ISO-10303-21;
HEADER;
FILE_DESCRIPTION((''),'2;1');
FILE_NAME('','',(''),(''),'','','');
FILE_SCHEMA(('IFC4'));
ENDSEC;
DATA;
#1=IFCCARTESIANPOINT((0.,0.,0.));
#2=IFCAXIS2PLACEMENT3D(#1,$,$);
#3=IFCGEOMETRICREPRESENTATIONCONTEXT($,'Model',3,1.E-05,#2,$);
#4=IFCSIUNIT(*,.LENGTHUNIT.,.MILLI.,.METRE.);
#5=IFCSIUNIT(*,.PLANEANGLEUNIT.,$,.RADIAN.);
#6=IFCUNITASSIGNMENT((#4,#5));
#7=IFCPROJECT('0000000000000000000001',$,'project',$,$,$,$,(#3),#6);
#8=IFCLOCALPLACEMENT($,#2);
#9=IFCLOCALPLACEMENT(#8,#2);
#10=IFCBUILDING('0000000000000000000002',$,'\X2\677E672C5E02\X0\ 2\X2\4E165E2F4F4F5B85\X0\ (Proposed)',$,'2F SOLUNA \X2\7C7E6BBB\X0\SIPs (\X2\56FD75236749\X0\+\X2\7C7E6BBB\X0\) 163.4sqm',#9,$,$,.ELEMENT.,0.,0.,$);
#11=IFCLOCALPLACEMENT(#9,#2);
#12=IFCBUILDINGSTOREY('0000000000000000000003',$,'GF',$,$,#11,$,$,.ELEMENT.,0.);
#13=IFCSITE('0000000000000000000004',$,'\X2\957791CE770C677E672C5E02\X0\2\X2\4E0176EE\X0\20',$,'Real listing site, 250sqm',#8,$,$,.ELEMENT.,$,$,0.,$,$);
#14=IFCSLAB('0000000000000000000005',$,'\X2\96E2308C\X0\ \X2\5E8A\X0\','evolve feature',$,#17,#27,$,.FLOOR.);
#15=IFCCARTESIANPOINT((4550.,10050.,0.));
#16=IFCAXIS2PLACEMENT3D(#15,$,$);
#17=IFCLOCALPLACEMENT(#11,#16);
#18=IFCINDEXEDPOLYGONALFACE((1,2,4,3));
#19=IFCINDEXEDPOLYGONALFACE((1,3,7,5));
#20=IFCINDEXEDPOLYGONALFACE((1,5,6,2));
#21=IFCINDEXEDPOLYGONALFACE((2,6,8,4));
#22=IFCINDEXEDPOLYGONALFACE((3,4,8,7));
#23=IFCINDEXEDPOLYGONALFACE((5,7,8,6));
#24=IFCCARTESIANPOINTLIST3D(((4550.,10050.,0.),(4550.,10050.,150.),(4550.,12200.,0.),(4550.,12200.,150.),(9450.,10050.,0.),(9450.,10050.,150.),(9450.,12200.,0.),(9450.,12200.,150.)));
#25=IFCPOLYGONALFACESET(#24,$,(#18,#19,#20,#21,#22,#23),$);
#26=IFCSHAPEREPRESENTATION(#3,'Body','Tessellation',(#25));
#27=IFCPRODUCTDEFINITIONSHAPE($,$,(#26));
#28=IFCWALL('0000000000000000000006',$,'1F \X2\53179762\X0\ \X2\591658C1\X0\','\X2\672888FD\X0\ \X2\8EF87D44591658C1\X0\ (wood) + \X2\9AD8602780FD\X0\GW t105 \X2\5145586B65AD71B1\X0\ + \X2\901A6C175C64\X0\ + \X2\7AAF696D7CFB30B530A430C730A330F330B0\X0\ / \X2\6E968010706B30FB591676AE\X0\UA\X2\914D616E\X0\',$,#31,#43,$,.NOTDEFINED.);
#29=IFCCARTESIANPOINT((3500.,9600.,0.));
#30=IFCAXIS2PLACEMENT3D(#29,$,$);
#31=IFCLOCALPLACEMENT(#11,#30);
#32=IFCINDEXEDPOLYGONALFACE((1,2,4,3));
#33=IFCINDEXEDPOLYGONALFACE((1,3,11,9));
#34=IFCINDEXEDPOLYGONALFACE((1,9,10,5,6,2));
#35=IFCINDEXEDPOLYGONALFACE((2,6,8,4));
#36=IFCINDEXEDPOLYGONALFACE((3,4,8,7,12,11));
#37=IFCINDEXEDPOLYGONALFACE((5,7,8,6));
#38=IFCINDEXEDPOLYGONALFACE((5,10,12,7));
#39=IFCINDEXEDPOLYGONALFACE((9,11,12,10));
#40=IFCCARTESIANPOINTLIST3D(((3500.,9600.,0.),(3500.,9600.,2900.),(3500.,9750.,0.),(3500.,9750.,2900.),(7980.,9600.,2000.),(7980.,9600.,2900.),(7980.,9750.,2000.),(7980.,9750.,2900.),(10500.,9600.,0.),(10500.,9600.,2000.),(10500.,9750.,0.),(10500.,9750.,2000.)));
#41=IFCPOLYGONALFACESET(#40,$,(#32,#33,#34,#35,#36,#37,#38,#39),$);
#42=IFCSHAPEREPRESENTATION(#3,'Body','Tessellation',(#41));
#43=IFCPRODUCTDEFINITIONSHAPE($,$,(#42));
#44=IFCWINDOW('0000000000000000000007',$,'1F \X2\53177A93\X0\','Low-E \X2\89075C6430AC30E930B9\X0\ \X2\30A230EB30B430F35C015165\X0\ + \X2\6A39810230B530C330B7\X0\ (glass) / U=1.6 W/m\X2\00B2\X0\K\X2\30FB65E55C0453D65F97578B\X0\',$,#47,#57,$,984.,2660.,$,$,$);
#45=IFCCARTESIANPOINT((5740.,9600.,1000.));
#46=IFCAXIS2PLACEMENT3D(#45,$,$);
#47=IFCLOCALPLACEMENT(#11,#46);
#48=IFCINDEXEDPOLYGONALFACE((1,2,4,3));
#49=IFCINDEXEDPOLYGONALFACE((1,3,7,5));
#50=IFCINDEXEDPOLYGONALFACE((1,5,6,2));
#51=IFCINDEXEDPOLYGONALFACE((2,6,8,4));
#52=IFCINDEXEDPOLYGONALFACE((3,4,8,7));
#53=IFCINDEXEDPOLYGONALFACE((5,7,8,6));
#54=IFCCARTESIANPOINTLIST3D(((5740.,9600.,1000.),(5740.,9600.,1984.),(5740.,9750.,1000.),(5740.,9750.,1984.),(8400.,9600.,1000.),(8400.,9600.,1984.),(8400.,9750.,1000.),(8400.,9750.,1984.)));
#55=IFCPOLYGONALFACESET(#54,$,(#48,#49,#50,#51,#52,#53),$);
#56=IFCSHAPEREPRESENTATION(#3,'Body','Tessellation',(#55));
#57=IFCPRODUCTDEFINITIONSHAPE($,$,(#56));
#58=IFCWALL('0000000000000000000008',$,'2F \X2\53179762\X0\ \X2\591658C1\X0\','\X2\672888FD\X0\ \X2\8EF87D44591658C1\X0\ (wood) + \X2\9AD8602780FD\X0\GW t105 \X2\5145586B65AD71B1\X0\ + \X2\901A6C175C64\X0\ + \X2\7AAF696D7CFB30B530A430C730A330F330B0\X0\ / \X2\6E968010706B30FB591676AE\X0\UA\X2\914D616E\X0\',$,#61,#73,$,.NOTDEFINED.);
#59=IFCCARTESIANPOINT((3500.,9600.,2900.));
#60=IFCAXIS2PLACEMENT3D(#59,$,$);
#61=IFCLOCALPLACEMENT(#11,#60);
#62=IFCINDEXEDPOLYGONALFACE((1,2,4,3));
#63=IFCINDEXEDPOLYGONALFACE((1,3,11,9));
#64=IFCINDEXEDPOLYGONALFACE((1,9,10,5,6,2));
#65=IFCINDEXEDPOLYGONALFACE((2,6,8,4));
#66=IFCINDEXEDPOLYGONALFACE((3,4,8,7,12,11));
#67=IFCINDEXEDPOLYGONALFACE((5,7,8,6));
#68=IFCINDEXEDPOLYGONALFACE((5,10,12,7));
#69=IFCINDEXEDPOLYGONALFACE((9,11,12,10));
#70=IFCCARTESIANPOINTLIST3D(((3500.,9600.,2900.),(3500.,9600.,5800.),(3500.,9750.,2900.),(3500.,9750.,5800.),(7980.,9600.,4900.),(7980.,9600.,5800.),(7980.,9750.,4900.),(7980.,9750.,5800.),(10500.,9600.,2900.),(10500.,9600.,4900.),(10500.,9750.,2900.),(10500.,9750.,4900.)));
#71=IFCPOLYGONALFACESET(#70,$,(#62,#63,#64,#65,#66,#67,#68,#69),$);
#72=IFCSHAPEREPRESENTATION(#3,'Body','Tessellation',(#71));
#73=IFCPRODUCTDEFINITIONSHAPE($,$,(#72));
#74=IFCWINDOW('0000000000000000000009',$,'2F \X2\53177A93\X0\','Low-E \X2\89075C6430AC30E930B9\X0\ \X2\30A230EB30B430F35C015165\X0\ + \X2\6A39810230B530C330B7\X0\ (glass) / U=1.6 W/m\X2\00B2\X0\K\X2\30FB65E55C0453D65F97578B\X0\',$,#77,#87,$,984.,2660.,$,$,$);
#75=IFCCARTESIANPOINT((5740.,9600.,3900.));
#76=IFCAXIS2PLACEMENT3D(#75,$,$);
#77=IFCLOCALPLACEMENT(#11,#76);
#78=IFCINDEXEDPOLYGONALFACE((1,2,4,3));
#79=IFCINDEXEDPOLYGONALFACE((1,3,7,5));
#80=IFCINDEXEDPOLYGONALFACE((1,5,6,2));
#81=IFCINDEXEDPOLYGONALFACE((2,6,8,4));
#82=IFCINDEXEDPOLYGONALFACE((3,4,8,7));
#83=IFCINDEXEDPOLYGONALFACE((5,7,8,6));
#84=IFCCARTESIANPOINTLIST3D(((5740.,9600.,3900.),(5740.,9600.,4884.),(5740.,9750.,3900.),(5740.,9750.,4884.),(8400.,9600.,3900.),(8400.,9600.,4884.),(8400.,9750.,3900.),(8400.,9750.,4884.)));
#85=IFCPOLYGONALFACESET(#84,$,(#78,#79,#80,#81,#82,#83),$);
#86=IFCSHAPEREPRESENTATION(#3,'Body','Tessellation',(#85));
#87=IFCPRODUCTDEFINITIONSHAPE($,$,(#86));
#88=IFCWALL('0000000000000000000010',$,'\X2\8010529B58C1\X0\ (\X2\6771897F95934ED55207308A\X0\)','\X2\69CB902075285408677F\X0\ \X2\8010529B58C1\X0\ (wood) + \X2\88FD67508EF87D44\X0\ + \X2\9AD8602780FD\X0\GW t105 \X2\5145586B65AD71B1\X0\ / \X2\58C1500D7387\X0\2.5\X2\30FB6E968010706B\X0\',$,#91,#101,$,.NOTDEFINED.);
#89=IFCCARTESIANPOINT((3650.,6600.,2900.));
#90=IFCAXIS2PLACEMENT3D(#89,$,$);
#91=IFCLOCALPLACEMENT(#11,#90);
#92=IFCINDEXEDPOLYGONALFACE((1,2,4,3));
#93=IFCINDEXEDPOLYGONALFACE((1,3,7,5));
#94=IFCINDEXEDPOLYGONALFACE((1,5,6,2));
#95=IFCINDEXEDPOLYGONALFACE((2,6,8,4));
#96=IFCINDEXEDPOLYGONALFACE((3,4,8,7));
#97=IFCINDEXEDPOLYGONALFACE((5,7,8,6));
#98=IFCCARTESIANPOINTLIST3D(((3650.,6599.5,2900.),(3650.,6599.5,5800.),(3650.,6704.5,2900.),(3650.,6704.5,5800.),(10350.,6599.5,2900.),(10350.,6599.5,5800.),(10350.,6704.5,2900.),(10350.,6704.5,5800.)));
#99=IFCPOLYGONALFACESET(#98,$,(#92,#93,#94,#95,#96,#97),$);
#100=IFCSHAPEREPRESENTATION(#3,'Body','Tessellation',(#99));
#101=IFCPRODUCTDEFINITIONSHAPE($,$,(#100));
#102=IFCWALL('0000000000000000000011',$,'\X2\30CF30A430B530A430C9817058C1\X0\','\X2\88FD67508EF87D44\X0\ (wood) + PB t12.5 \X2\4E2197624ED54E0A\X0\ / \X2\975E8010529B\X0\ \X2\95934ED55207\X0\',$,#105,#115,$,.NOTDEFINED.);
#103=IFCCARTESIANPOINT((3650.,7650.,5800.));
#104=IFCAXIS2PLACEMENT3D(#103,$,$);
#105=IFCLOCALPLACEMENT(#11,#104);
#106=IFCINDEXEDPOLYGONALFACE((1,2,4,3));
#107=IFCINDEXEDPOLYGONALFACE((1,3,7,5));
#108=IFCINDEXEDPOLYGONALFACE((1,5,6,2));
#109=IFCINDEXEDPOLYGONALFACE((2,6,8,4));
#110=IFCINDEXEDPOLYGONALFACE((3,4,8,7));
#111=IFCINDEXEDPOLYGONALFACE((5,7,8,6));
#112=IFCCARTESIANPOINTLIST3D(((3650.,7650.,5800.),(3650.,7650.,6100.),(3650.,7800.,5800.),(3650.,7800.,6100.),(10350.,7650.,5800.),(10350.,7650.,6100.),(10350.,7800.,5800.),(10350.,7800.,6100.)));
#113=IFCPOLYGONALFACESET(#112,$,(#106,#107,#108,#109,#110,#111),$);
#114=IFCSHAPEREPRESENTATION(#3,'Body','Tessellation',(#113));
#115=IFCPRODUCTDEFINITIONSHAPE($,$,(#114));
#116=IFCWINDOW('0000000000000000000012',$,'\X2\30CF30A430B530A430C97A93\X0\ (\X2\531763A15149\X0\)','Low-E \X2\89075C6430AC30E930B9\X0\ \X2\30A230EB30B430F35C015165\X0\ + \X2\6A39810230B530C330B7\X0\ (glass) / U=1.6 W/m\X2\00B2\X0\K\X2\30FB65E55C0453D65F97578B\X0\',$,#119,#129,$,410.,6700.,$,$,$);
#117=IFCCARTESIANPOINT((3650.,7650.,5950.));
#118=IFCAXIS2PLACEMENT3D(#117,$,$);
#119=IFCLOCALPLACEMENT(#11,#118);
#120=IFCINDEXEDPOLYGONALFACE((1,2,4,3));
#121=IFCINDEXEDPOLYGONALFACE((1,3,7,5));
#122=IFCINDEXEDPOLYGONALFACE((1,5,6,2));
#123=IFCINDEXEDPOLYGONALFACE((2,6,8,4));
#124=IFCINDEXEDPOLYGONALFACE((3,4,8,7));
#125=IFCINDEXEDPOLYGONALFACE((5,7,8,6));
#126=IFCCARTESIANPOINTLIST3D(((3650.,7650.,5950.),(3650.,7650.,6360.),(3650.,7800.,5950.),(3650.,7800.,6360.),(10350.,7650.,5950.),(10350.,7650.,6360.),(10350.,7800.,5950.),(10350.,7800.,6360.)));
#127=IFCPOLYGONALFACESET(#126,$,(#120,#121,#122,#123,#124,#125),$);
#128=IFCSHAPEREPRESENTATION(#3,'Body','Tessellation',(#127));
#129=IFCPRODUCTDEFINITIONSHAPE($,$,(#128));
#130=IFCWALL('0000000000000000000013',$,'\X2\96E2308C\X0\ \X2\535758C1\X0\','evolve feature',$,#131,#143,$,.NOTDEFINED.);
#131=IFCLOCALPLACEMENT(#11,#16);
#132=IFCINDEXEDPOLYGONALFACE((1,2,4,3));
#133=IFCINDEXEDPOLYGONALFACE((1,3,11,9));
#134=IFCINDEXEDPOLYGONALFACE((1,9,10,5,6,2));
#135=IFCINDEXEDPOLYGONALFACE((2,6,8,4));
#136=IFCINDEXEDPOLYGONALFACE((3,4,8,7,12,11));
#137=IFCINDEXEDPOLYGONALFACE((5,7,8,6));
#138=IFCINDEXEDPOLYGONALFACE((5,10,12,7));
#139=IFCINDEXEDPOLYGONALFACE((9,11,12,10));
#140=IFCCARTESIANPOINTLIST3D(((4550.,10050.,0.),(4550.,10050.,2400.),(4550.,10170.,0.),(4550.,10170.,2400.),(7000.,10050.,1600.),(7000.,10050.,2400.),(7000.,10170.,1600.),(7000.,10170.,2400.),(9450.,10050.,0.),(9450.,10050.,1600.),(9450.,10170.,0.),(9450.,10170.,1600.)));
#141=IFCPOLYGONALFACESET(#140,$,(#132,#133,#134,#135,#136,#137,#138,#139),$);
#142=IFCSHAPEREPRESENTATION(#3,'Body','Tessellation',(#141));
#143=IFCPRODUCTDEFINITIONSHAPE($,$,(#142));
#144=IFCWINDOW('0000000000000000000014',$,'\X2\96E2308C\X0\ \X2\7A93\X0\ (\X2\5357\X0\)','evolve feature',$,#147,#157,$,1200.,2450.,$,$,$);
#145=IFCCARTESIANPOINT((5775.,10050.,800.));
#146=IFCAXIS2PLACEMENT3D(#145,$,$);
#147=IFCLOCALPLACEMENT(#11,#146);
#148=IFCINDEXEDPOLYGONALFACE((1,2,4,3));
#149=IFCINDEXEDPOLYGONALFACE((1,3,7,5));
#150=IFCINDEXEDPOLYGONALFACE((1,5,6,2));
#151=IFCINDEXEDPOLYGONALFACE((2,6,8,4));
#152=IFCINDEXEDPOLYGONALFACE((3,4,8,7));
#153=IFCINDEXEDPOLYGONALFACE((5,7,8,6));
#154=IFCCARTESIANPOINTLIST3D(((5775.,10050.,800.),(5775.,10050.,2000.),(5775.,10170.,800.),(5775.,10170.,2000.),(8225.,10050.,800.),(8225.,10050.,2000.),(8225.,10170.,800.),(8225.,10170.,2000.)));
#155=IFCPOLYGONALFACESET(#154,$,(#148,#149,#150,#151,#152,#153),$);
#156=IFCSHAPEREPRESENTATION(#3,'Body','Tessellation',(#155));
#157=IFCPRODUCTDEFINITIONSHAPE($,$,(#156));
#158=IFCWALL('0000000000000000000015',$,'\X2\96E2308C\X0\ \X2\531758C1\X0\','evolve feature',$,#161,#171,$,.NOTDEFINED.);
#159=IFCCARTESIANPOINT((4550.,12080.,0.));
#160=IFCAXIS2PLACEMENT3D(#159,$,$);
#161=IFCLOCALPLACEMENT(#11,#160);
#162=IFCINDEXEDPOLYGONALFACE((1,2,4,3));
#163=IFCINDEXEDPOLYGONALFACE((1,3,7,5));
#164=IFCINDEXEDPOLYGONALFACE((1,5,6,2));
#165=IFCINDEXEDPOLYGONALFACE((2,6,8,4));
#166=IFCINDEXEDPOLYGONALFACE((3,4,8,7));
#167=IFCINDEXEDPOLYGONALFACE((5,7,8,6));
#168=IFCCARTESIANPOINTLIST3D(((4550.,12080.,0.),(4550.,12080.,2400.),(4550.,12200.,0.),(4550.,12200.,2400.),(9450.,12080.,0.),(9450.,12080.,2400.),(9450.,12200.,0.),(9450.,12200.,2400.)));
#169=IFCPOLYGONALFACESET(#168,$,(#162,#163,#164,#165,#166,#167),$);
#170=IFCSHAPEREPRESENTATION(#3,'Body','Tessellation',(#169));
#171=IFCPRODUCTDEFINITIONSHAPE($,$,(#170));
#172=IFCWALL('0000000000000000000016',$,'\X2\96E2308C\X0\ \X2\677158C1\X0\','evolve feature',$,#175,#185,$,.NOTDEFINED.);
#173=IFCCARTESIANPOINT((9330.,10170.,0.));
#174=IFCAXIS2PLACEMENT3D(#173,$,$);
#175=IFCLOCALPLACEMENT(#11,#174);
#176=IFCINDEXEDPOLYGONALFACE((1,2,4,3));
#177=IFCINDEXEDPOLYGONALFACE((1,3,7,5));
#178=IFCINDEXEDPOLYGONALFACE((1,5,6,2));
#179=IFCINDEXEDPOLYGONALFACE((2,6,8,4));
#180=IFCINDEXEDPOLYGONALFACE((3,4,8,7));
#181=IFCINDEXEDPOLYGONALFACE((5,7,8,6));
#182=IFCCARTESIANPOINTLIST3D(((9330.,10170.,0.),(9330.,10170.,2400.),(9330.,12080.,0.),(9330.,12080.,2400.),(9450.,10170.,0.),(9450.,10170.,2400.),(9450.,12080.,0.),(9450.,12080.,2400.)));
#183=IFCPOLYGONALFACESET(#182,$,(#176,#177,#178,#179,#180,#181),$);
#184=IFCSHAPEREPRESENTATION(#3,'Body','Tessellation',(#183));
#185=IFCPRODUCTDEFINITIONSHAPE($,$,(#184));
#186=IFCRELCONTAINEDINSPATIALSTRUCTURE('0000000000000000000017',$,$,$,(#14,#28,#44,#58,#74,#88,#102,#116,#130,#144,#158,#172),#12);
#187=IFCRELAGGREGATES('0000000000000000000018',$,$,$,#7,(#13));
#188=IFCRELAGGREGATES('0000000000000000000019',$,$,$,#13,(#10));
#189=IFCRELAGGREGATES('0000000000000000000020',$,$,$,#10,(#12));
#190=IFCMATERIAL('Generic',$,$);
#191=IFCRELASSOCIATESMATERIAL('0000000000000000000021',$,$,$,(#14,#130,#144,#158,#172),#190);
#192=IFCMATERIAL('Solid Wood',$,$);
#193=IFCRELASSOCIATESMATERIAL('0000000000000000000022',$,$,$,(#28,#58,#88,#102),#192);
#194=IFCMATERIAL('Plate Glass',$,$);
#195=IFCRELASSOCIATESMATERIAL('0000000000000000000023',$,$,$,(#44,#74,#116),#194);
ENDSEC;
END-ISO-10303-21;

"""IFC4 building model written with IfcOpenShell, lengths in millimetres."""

from ifc_helpers import new_model, si_unit, frame, frame_2d, origin, place, context, project, spatial, rectangle, extrude, material, element, fill, save


model = new_model("IFC4")

# Units and contexts
model_context = context("Model", 3, precision=1e-05, world=origin())
ifc_project = project(units=[si_unit("LENGTHUNIT", "METRE", prefix="MILLI"), si_unit("PLANEANGLEUNIT", "RADIAN")], contexts=[model_context])

# Site, building, storey
site_placement = place(None, origin())
site = spatial("IfcSite", under=ifc_project, at=site_placement, Name="長野県松本市2丁目20", ObjectType="Real listing site, 250sqm", CompositionType="ELEMENT", RefElevation=0.0)
building_placement = place(site_placement, origin())
building = spatial("IfcBuilding", under=site, at=building_placement, Name="松本市 2世帯住宅 (Proposed)", ObjectType="2F SOLUNA 籾殻SIPs (国産杉+籾殻) 163.4sqm", CompositionType="ELEMENT", ElevationOfRefHeight=0.0, ElevationOfTerrain=0.0)
storey_placement = place(building_placement, origin())
storey = spatial("IfcBuildingStorey", under=building, at=storey_placement, Name="GF", CompositionType="ELEMENT", Elevation=0.0)

# Slab
ifc_material_1 = material(Name="Generic")
slab_placement = place(storey_placement, frame((4550.0, 10050.0, 0.0)))
element("IfcSlab", 1, at=slab_placement, inside=storey, material=ifc_material_1, Name="離れ 床", Description="evolve feature", PredefinedType="FLOOR", context=model_context, shape_type="SweptSolid", body=[
    extrude(rectangle(XDim=4900.0, YDim=2150.0, at=frame_2d((2450.0, 1075.0))), frame((4550.0, 10050.0, 0.0)), (0.0, 0.0, 1.0), 150.0),
])

# Wall, opening, window
ifc_material_2 = material(Name="Solid Wood")
wall_1_placement = place(storey_placement, frame((3500.0, 9600.0, 0.0)))
wall_1 = element("IfcWall", 2, at=wall_1_placement, inside=storey, material=ifc_material_2, Name="1F 北面 外壁", Description="木製 軸組外壁 (wood) + 高性能GW t105 充填断熱 + 通気層 + 窯業系サイディング / 準耐火・外皮UA配慮", PredefinedType="NOTDEFINED", context=model_context, shape_type="SweptSolid", body=[
    extrude(rectangle(XDim=7000.0, YDim=150.0, at=frame_2d((3500.0, 75.0))), frame((3500.0, 9600.0, 0.0)), (0.0, 0.0, 1.0), 2900.0),
])
opening_1_placement = place(storey_placement, frame((5740.0, 9600.0, 1000.0)))
opening_1 = element("IfcOpeningElement", 3, at=opening_1_placement, cuts=wall_1, PredefinedType="NOTDEFINED", context=model_context, shape_type="SweptSolid", body=[
    extrude(rectangle(XDim=2660.0, YDim=150.0, at=frame_2d((1330.0, 75.0))), frame((5740.0, 9600.0, 1000.0)), (0.0, 0.0, 1.0), 984.0),
])
ifc_material_3 = material(Name="Plate Glass")
window_1_placement = place(storey_placement, frame((5740.0, 9600.0, 1000.0)))
window_1 = element("IfcWindow", 4, at=window_1_placement, inside=storey, material=ifc_material_3, Name="1F 北窓", Description="Low-E 複層ガラス アルゴン封入 + 樹脂サッシ (glass) / U=1.6 W/m²K・日射取得型", OverallHeight=984.0, OverallWidth=2660.0, context=model_context, shape_type="SweptSolid", body=[
    extrude(rectangle(XDim=2660.0, YDim=150.0, at=frame_2d((1330.0, 75.0))), frame((5740.0, 9600.0, 1000.0)), (0.0, 0.0, 1.0), 984.0),
])
fill(opening_1, window_1)

# Wall, opening, window
wall_2_placement = place(storey_placement, frame((3500.0, 9600.0, 2900.0)))
wall_2 = element("IfcWall", 5, at=wall_2_placement, inside=storey, material=ifc_material_2, Name="2F 北面 外壁", Description="木製 軸組外壁 (wood) + 高性能GW t105 充填断熱 + 通気層 + 窯業系サイディング / 準耐火・外皮UA配慮", PredefinedType="NOTDEFINED", context=model_context, shape_type="SweptSolid", body=[
    extrude(rectangle(XDim=7000.0, YDim=150.0, at=frame_2d((3500.0, 75.0))), frame((3500.0, 9600.0, 2900.0)), (0.0, 0.0, 1.0), 2900.0),
])
opening_2_placement = place(storey_placement, frame((5740.0, 9600.0, 3900.0)))
opening_2 = element("IfcOpeningElement", 6, at=opening_2_placement, cuts=wall_2, PredefinedType="NOTDEFINED", context=model_context, shape_type="SweptSolid", body=[
    extrude(rectangle(XDim=2660.0, YDim=150.0, at=frame_2d((1330.0, 75.0))), frame((5740.0, 9600.0, 3900.0)), (0.0, 0.0, 1.0), 984.0),
])
window_2_placement = place(storey_placement, frame((5740.0, 9600.0, 3900.0)))
window_2 = element("IfcWindow", 7, at=window_2_placement, inside=storey, material=ifc_material_3, Name="2F 北窓", Description="Low-E 複層ガラス アルゴン封入 + 樹脂サッシ (glass) / U=1.6 W/m²K・日射取得型", OverallHeight=984.0, OverallWidth=2660.0, context=model_context, shape_type="SweptSolid", body=[
    extrude(rectangle(XDim=2660.0, YDim=150.0, at=frame_2d((1330.0, 75.0))), frame((5740.0, 9600.0, 3900.0)), (0.0, 0.0, 1.0), 984.0),
])
fill(opening_2, window_2)

# Wall
wall_3_placement = place(storey_placement, frame((3650.0, 6600.0, 2900.0)))
element("IfcWall", 8, at=wall_3_placement, inside=storey, material=ifc_material_2, Name="耐力壁 (東西間仕切り)", Description="構造用合板 耐力壁 (wood) + 製材軸組 + 高性能GW t105 充填断熱 / 壁倍率2.5・準耐火", PredefinedType="NOTDEFINED", context=model_context, shape_type="SweptSolid", body=[
    extrude(rectangle(XDim=6700.0, YDim=105.0, at=frame_2d((3350.0, 52.0))), frame((3650.0, 6600.0, 2900.0)), (0.0, 0.0, 1.0), 2900.0),
])

# Walls, openings, windows
wall_4_placement = place(storey_placement, frame((3650.0, 7650.0, 5800.0)))
wall_4 = element("IfcWall", 9, at=wall_4_placement, inside=storey, material=ifc_material_2, Name="ハイサイド腰壁", Description="製材軸組 (wood) + PB t12.5 両面仕上 / 非耐力 間仕切", PredefinedType="NOTDEFINED", context=model_context, shape_type="SweptSolid", body=[
    extrude(rectangle(XDim=6700.0, YDim=150.0, at=frame_2d((3350.0, 75.0))), frame((3650.0, 7650.0, 5800.0)), (0.0, 0.0, 1.0), 700.0),
])
opening_3_placement = place(storey_placement, frame((3650.0, 7650.0, 5950.0)))
opening_3 = element("IfcOpeningElement", 10, at=opening_3_placement, cuts=wall_4, PredefinedType="NOTDEFINED", context=model_context, shape_type="SweptSolid", body=[
    extrude(rectangle(XDim=6700.0, YDim=150.0, at=frame_2d((3350.0, 75.0))), frame((3650.0, 7650.0, 5950.0)), (0.0, 0.0, 1.0), 410.0),
])
window_3_placement = place(storey_placement, frame((3650.0, 7650.0, 5950.0)))
window_3 = element("IfcWindow", 11, at=window_3_placement, inside=storey, material=ifc_material_3, Name="ハイサイド窓 (北採光)", Description="Low-E 複層ガラス アルゴン封入 + 樹脂サッシ (glass) / U=1.6 W/m²K・日射取得型", OverallHeight=410.0, OverallWidth=6700.0, context=model_context, shape_type="SweptSolid", body=[
    extrude(rectangle(XDim=6700.0, YDim=150.0, at=frame_2d((3350.0, 75.0))), frame((3650.0, 7650.0, 5950.0)), (0.0, 0.0, 1.0), 410.0),
])
fill(opening_3, window_3)
wall_5_placement = place(storey_placement, frame((4550.0, 10050.0, 0.0)))
wall_5 = element("IfcWall", 12, at=wall_5_placement, inside=storey, material=ifc_material_1, Name="離れ 南壁", Description="evolve feature", PredefinedType="NOTDEFINED", context=model_context, shape_type="SweptSolid", body=[
    extrude(rectangle(XDim=4900.0, YDim=120.0, at=frame_2d((2450.0, 60.0))), frame((4550.0, 10050.0, 0.0)), (0.0, 0.0, 1.0), 2400.0),
])
opening_4_placement = place(storey_placement, frame((5775.0, 10050.0, 800.0)))
opening_4 = element("IfcOpeningElement", 13, at=opening_4_placement, cuts=wall_5, PredefinedType="NOTDEFINED", context=model_context, shape_type="SweptSolid", body=[
    extrude(rectangle(XDim=2450.0, YDim=120.0, at=frame_2d((1225.0, 60.0))), frame((5775.0, 10050.0, 800.0)), (0.0, 0.0, 1.0), 1200.0),
])
window_4_placement = place(storey_placement, frame((5775.0, 10050.0, 800.0)))
window_4 = element("IfcWindow", 14, at=window_4_placement, inside=storey, material=ifc_material_1, Name="離れ 窓 (南)", Description="evolve feature", OverallHeight=1200.0, OverallWidth=2450.0, context=model_context, shape_type="SweptSolid", body=[
    extrude(rectangle(XDim=2450.0, YDim=120.0, at=frame_2d((1225.0, 60.0))), frame((5775.0, 10050.0, 800.0)), (0.0, 0.0, 1.0), 1200.0),
])
fill(opening_4, window_4)

# Walls
wall_6_placement = place(storey_placement, frame((4550.0, 12080.0, 0.0)))
element("IfcWall", 15, at=wall_6_placement, inside=storey, material=ifc_material_1, Name="離れ 北壁", Description="evolve feature", PredefinedType="NOTDEFINED", context=model_context, shape_type="SweptSolid", body=[
    extrude(rectangle(XDim=4900.0, YDim=120.0, at=frame_2d((2450.0, 60.0))), frame((4550.0, 12080.0, 0.0)), (0.0, 0.0, 1.0), 2400.0),
])
wall_7_placement = place(storey_placement, frame((9330.0, 10170.0, 0.0)))
element("IfcWall", 16, at=wall_7_placement, inside=storey, material=ifc_material_1, Name="離れ 東壁", Description="evolve feature", PredefinedType="NOTDEFINED", context=model_context, shape_type="SweptSolid", body=[
    extrude(rectangle(XDim=120.0, YDim=1910.0, at=frame_2d((60.0, 955.0))), frame((9330.0, 10170.0, 0.0)), (0.0, 0.0, 1.0), 2400.0),
])

save(model, "model.ifc")
